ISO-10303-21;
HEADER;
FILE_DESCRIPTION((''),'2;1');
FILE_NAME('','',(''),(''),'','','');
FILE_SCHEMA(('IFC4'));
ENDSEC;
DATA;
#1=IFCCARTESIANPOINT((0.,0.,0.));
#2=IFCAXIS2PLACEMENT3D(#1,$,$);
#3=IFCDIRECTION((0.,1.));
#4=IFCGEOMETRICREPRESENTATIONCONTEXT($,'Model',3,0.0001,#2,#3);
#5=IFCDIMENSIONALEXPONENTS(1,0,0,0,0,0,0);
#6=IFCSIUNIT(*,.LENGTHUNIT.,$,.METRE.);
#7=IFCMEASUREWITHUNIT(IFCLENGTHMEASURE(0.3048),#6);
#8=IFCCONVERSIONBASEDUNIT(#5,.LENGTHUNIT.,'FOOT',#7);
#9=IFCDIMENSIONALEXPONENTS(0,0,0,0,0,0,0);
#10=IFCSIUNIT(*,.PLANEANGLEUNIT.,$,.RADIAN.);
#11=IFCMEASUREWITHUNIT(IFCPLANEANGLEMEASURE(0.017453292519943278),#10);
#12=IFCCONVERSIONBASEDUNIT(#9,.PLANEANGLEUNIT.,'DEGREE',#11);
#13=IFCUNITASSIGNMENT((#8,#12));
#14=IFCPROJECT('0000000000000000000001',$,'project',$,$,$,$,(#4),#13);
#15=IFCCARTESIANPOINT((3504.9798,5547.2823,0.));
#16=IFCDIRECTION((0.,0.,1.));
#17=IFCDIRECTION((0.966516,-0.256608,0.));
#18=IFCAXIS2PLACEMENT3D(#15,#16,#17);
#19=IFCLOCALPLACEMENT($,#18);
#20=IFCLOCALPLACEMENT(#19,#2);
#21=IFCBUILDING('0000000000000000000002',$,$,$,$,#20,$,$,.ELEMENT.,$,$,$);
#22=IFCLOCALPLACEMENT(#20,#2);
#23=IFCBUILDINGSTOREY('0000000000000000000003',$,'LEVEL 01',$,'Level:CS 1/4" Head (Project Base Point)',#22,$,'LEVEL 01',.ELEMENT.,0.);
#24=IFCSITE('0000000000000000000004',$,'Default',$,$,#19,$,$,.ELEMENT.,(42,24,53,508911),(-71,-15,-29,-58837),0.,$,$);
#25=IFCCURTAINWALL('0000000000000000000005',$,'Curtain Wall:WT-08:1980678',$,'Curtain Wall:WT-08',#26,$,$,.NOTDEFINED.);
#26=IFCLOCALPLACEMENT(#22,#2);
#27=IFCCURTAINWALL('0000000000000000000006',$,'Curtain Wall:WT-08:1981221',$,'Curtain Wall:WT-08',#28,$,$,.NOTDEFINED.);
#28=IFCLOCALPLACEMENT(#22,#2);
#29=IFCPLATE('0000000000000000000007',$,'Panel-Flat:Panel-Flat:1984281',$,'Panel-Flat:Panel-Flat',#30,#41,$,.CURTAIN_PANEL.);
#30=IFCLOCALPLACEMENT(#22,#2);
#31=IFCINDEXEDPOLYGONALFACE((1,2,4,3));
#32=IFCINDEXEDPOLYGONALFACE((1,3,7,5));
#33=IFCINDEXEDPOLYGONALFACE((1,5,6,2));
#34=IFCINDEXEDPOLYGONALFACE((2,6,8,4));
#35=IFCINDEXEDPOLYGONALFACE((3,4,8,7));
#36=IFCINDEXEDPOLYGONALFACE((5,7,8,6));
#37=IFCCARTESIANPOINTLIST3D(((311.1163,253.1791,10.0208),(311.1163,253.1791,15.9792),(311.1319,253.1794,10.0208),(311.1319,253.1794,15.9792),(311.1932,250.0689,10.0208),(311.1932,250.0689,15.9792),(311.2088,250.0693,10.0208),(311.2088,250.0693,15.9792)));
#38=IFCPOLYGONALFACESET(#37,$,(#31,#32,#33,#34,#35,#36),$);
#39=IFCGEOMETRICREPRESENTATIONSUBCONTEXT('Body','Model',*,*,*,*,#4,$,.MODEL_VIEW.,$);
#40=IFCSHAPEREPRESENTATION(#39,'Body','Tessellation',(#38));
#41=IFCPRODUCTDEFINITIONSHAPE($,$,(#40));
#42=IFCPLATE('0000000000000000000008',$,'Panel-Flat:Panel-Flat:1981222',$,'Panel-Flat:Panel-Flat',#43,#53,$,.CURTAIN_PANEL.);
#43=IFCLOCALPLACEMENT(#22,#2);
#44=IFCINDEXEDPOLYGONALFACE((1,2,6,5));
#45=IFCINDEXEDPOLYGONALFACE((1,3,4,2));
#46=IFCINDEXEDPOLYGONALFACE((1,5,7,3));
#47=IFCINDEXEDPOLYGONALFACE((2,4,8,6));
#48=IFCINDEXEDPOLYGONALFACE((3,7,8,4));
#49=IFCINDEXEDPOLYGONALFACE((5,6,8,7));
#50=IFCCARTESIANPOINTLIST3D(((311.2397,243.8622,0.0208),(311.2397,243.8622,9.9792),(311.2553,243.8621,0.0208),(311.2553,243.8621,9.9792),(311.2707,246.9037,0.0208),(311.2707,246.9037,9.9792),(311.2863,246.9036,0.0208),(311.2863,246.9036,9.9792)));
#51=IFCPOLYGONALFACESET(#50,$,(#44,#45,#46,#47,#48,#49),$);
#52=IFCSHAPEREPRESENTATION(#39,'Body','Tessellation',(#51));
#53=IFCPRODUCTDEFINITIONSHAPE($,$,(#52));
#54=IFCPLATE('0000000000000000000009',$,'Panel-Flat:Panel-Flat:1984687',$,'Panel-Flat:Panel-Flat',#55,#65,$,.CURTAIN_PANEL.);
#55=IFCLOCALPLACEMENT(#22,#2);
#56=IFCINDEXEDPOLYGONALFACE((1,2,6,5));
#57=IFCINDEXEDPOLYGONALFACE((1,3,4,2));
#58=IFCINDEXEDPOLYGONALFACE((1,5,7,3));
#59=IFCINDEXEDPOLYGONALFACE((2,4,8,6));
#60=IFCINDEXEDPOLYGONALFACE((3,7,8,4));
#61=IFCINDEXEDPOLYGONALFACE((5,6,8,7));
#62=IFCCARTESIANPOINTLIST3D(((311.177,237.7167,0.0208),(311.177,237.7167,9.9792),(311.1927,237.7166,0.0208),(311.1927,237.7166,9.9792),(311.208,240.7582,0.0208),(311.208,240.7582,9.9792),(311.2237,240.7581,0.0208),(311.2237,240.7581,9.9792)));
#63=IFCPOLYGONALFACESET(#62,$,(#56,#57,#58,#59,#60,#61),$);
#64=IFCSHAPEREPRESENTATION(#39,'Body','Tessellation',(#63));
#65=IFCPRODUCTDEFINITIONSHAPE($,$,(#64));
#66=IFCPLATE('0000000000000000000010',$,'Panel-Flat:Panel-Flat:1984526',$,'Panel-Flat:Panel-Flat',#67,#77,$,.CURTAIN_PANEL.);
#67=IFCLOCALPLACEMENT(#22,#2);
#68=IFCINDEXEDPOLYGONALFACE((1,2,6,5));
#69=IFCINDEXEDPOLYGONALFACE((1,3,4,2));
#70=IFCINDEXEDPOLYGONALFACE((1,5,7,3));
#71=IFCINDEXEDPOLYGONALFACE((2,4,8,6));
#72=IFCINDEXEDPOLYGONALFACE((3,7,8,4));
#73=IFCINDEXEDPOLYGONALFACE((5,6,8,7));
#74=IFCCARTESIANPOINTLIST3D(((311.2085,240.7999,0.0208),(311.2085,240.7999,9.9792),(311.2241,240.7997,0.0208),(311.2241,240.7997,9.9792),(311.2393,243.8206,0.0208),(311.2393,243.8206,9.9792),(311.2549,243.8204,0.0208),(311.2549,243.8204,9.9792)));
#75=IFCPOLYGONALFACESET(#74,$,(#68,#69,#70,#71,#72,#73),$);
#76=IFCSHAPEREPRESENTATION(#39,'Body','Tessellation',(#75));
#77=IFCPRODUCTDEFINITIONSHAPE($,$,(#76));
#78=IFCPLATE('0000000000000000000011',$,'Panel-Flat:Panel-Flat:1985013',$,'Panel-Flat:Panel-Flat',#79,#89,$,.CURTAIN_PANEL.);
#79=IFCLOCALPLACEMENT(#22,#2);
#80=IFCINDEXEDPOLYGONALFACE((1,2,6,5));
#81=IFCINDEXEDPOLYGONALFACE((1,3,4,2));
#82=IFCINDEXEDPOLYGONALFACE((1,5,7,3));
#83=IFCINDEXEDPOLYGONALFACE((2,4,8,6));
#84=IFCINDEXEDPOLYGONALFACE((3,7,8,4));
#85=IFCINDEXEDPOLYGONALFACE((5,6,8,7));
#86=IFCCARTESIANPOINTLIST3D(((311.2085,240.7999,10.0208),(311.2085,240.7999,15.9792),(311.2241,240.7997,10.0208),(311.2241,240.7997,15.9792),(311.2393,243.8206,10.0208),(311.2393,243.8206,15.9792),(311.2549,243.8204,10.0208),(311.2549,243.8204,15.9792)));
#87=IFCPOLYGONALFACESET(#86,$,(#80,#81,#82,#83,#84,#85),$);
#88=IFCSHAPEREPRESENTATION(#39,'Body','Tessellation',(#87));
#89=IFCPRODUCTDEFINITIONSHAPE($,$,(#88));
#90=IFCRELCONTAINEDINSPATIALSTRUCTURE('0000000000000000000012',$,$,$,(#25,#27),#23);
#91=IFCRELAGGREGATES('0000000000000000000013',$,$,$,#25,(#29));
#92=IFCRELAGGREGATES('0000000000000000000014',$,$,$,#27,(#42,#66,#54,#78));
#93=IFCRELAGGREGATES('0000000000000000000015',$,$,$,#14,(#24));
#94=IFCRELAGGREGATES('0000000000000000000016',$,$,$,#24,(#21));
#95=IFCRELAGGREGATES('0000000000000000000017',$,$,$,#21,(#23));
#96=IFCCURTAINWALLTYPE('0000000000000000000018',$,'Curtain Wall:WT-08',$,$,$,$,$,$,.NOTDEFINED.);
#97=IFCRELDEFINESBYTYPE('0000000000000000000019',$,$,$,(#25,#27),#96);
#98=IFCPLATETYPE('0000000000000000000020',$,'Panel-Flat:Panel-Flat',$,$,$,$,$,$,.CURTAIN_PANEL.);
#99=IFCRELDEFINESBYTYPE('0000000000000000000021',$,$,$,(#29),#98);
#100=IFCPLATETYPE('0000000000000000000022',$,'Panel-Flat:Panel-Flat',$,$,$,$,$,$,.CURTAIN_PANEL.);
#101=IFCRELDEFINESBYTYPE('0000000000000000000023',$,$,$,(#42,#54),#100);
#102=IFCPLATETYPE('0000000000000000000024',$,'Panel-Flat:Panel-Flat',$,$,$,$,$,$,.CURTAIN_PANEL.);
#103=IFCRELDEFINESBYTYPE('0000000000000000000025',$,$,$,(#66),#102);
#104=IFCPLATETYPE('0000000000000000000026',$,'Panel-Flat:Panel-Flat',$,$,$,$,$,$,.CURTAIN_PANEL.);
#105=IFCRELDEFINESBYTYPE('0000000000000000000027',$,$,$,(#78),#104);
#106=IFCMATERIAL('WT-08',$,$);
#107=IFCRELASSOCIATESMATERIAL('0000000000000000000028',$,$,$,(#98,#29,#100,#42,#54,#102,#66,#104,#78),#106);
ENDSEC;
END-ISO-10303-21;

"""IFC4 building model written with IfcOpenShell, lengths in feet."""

from ifc_helpers import new_model, entity, si_unit, converted_unit, direction, frame, origin, place, context, subcontext, project, spatial, indexed_curve, outline, extrude, source, transform, mapped, material, type_object, type_shapes, element, aggregate, save


model = new_model("IFC4")

# Units and contexts
model_context = context("Model", 3, precision=0.0001, world=origin(), true_north=direction((0.0, 1.0)))
body_context = subcontext(model_context, "Body", "Model", "MODEL_VIEW")
ifc_project = project(units=[converted_unit("LENGTHUNIT", "FOOT", entity("IfcLengthMeasure", 0.3048), si_unit("LENGTHUNIT", "METRE"), dimensions=[1, 0, 0, 0, 0, 0, 0]), converted_unit("PLANEANGLEUNIT", "DEGREE", entity("IfcPlaneAngleMeasure", 0.017453292519943278), si_unit("PLANEANGLEUNIT", "RADIAN"), dimensions=[0, 0, 0, 0, 0, 0, 0])], contexts=[model_context])

# Site, building, storey
site_placement = place(None, frame((3504.9798, 5547.2823, 0.0), z_axis=(0.0, 0.0, 1.0), x_axis=(0.966516, -0.256608, 0.0)))
site = spatial("IfcSite", under=ifc_project, at=site_placement, Name="Default", CompositionType="ELEMENT", RefLatitude=(42, 24, 53, 508911), RefLongitude=(-71, -15, -29, -58837), RefElevation=0.0)
building_placement = place(site_placement, origin())
building = spatial("IfcBuilding", under=site, at=building_placement, CompositionType="ELEMENT")
storey_placement = place(building_placement, origin())
storey = spatial("IfcBuildingStorey", under=building, at=storey_placement, Name="LEVEL 01", ObjectType="Level:CS 1/4\" Head (Project Base Point)", LongName="LEVEL 01", CompositionType="ELEMENT", Elevation=0.0)

# Curtain walls
curtain_wall_type_1 = type_object("IfcCurtainWallType", Name="Curtain Wall:WT-08", PredefinedType="NOTDEFINED")
curtain_wall_1_placement = place(storey_placement, origin())
curtain_wall_1 = element("IfcCurtainWall", 1, at=curtain_wall_1_placement, inside=storey, type_object=curtain_wall_type_1, Name="Curtain Wall:WT-08:1980678", ObjectType="Curtain Wall:WT-08", PredefinedType="NOTDEFINED")
ifc_material_1 = material(Name="WT-08")
curtain_wall_2_placement = place(storey_placement, origin())
curtain_wall_2 = element("IfcCurtainWall", 2, at=curtain_wall_2_placement, inside=storey, type_object=curtain_wall_type_1, Name="Curtain Wall:WT-08:1981221", ObjectType="Curtain Wall:WT-08", PredefinedType="NOTDEFINED")

# Plates
plate_type_1 = type_object("IfcPlateType", Name="Panel-Flat:Panel-Flat", PredefinedType="CURTAIN_PANEL", material=ifc_material_1)
shared_shape_1 = source(origin(), body_context, "Body", "SweptSolid", [
    extrude(outline(indexed_curve([(-0.0078, -1.5556), (0.0078, -1.5556), (0.0078, 1.5556), (-0.0078, 1.5556), (-0.0078, -1.5556)], self_intersect=False)), frame((0.0, -0.0078, 0.0208), z_axis=(0.0, 0.0, 1.0), x_axis=(0.0, -1.0, 0.0)), (0.0, 0.0, 1.0), 5.9583),
])
type_shapes(plate_type_1, [shared_shape_1])
plate_1_placement = place(curtain_wall_1_placement, frame((311.1704, 251.6244, 10.0), z_axis=(0.0, 0.0, 1.0), x_axis=(0.024711, -0.999695, 0.0)))
plate_1 = element("IfcPlate", 3, at=plate_1_placement, type_object=plate_type_1, material=ifc_material_1, Name="Panel-Flat:Panel-Flat:1984281", ObjectType="Panel-Flat:Panel-Flat", PredefinedType="CURTAIN_PANEL", context=body_context, shape_type="MappedRepresentation", body=[
    mapped(shared_shape_1, transform((0.0, 0.0, 0.0), scale=1.0)),
])
aggregate(curtain_wall_1, [plate_1])
plate_type_2 = type_object("IfcPlateType", Name="Panel-Flat:Panel-Flat", PredefinedType="CURTAIN_PANEL", material=ifc_material_1)
shared_shape_2 = source(origin(), body_context, "Body", "SweptSolid", [
    extrude(outline(indexed_curve([(-0.0078, -1.5208), (0.0078, -1.5208), (0.0078, 1.5208), (-0.0078, 1.5208), (-0.0078, -1.5208)], self_intersect=False)), frame((0.0, -0.0078, 0.0208), z_axis=(0.0, 0.0, 1.0), x_axis=(0.0, -1.0, 0.0)), (0.0, 0.0, 1.0), 9.9583),
])
type_shapes(plate_type_2, [shared_shape_2])
plate_2_placement = place(curtain_wall_2_placement, frame((311.2708, 245.3828, 0.0), z_axis=(0.0, 0.0, 1.0), x_axis=(-0.010193, -0.999948, 0.0)))
plate_2 = element("IfcPlate", 4, at=plate_2_placement, type_object=plate_type_2, material=ifc_material_1, Name="Panel-Flat:Panel-Flat:1981222", ObjectType="Panel-Flat:Panel-Flat", PredefinedType="CURTAIN_PANEL", context=body_context, shape_type="MappedRepresentation", body=[
    mapped(shared_shape_2, transform((0.0, 0.0, 0.0), scale=1.0)),
])
plate_3_placement = place(curtain_wall_2_placement, frame((311.2082, 239.2373, 0.0), z_axis=(0.0, 0.0, 1.0), x_axis=(-0.010193, -0.999948, 0.0)))
plate_3 = element("IfcPlate", 5, at=plate_3_placement, type_object=plate_type_2, material=ifc_material_1, Name="Panel-Flat:Panel-Flat:1984687", ObjectType="Panel-Flat:Panel-Flat", PredefinedType="CURTAIN_PANEL", context=body_context, shape_type="MappedRepresentation", body=[
    mapped(shared_shape_2, transform((0.0, 0.0, 0.0), scale=1.0)),
])
plate_type_3 = type_object("IfcPlateType", Name="Panel-Flat:Panel-Flat", PredefinedType="CURTAIN_PANEL", material=ifc_material_1)
shared_shape_3 = source(origin(), body_context, "Body", "SweptSolid", [
    extrude(outline(indexed_curve([(-0.0078, -1.5104), (0.0078, -1.5104), (0.0078, 1.5104), (-0.0078, 1.5104), (-0.0078, -1.5104)], self_intersect=False)), frame((0.0, -0.0078, 0.0208), z_axis=(0.0, 0.0, 1.0), x_axis=(0.0, -1.0, 0.0)), (0.0, 0.0, 1.0), 9.9583),
])
type_shapes(plate_type_3, [shared_shape_3])
plate_4_placement = place(curtain_wall_2_placement, frame((311.2395, 242.3101, 0.0), z_axis=(0.0, 0.0, 1.0), x_axis=(-0.010193, -0.999948, 0.0)))
plate_4 = element("IfcPlate", 6, at=plate_4_placement, type_object=plate_type_3, material=ifc_material_1, Name="Panel-Flat:Panel-Flat:1984526", ObjectType="Panel-Flat:Panel-Flat", PredefinedType="CURTAIN_PANEL", context=body_context, shape_type="MappedRepresentation", body=[
    mapped(shared_shape_3, transform((0.0, 0.0, 0.0), scale=1.0)),
])
plate_type_4 = type_object("IfcPlateType", Name="Panel-Flat:Panel-Flat", PredefinedType="CURTAIN_PANEL", material=ifc_material_1)
shared_shape_4 = source(origin(), body_context, "Body", "SweptSolid", [
    extrude(outline(indexed_curve([(-0.0078, -1.5104), (0.0078, -1.5104), (0.0078, 1.5104), (-0.0078, 1.5104), (-0.0078, -1.5104)], self_intersect=False)), frame((0.0, -0.0078, 0.0208), z_axis=(0.0, 0.0, 1.0), x_axis=(0.0, -1.0, 0.0)), (0.0, 0.0, 1.0), 5.9583),
])
type_shapes(plate_type_4, [shared_shape_4])
plate_5_placement = place(curtain_wall_2_placement, frame((311.2395, 242.3101, 10.0), z_axis=(0.0, 0.0, 1.0), x_axis=(-0.010193, -0.999948, 0.0)))
plate_5 = element("IfcPlate", 7, at=plate_5_placement, type_object=plate_type_4, material=ifc_material_1, Name="Panel-Flat:Panel-Flat:1985013", ObjectType="Panel-Flat:Panel-Flat", PredefinedType="CURTAIN_PANEL", context=body_context, shape_type="MappedRepresentation", body=[
    mapped(shared_shape_4, transform((0.0, 0.0, 0.0), scale=1.0)),
])
aggregate(curtain_wall_2, [plate_2, plate_4, plate_3, plate_5])

save(model, "model.ifc")
